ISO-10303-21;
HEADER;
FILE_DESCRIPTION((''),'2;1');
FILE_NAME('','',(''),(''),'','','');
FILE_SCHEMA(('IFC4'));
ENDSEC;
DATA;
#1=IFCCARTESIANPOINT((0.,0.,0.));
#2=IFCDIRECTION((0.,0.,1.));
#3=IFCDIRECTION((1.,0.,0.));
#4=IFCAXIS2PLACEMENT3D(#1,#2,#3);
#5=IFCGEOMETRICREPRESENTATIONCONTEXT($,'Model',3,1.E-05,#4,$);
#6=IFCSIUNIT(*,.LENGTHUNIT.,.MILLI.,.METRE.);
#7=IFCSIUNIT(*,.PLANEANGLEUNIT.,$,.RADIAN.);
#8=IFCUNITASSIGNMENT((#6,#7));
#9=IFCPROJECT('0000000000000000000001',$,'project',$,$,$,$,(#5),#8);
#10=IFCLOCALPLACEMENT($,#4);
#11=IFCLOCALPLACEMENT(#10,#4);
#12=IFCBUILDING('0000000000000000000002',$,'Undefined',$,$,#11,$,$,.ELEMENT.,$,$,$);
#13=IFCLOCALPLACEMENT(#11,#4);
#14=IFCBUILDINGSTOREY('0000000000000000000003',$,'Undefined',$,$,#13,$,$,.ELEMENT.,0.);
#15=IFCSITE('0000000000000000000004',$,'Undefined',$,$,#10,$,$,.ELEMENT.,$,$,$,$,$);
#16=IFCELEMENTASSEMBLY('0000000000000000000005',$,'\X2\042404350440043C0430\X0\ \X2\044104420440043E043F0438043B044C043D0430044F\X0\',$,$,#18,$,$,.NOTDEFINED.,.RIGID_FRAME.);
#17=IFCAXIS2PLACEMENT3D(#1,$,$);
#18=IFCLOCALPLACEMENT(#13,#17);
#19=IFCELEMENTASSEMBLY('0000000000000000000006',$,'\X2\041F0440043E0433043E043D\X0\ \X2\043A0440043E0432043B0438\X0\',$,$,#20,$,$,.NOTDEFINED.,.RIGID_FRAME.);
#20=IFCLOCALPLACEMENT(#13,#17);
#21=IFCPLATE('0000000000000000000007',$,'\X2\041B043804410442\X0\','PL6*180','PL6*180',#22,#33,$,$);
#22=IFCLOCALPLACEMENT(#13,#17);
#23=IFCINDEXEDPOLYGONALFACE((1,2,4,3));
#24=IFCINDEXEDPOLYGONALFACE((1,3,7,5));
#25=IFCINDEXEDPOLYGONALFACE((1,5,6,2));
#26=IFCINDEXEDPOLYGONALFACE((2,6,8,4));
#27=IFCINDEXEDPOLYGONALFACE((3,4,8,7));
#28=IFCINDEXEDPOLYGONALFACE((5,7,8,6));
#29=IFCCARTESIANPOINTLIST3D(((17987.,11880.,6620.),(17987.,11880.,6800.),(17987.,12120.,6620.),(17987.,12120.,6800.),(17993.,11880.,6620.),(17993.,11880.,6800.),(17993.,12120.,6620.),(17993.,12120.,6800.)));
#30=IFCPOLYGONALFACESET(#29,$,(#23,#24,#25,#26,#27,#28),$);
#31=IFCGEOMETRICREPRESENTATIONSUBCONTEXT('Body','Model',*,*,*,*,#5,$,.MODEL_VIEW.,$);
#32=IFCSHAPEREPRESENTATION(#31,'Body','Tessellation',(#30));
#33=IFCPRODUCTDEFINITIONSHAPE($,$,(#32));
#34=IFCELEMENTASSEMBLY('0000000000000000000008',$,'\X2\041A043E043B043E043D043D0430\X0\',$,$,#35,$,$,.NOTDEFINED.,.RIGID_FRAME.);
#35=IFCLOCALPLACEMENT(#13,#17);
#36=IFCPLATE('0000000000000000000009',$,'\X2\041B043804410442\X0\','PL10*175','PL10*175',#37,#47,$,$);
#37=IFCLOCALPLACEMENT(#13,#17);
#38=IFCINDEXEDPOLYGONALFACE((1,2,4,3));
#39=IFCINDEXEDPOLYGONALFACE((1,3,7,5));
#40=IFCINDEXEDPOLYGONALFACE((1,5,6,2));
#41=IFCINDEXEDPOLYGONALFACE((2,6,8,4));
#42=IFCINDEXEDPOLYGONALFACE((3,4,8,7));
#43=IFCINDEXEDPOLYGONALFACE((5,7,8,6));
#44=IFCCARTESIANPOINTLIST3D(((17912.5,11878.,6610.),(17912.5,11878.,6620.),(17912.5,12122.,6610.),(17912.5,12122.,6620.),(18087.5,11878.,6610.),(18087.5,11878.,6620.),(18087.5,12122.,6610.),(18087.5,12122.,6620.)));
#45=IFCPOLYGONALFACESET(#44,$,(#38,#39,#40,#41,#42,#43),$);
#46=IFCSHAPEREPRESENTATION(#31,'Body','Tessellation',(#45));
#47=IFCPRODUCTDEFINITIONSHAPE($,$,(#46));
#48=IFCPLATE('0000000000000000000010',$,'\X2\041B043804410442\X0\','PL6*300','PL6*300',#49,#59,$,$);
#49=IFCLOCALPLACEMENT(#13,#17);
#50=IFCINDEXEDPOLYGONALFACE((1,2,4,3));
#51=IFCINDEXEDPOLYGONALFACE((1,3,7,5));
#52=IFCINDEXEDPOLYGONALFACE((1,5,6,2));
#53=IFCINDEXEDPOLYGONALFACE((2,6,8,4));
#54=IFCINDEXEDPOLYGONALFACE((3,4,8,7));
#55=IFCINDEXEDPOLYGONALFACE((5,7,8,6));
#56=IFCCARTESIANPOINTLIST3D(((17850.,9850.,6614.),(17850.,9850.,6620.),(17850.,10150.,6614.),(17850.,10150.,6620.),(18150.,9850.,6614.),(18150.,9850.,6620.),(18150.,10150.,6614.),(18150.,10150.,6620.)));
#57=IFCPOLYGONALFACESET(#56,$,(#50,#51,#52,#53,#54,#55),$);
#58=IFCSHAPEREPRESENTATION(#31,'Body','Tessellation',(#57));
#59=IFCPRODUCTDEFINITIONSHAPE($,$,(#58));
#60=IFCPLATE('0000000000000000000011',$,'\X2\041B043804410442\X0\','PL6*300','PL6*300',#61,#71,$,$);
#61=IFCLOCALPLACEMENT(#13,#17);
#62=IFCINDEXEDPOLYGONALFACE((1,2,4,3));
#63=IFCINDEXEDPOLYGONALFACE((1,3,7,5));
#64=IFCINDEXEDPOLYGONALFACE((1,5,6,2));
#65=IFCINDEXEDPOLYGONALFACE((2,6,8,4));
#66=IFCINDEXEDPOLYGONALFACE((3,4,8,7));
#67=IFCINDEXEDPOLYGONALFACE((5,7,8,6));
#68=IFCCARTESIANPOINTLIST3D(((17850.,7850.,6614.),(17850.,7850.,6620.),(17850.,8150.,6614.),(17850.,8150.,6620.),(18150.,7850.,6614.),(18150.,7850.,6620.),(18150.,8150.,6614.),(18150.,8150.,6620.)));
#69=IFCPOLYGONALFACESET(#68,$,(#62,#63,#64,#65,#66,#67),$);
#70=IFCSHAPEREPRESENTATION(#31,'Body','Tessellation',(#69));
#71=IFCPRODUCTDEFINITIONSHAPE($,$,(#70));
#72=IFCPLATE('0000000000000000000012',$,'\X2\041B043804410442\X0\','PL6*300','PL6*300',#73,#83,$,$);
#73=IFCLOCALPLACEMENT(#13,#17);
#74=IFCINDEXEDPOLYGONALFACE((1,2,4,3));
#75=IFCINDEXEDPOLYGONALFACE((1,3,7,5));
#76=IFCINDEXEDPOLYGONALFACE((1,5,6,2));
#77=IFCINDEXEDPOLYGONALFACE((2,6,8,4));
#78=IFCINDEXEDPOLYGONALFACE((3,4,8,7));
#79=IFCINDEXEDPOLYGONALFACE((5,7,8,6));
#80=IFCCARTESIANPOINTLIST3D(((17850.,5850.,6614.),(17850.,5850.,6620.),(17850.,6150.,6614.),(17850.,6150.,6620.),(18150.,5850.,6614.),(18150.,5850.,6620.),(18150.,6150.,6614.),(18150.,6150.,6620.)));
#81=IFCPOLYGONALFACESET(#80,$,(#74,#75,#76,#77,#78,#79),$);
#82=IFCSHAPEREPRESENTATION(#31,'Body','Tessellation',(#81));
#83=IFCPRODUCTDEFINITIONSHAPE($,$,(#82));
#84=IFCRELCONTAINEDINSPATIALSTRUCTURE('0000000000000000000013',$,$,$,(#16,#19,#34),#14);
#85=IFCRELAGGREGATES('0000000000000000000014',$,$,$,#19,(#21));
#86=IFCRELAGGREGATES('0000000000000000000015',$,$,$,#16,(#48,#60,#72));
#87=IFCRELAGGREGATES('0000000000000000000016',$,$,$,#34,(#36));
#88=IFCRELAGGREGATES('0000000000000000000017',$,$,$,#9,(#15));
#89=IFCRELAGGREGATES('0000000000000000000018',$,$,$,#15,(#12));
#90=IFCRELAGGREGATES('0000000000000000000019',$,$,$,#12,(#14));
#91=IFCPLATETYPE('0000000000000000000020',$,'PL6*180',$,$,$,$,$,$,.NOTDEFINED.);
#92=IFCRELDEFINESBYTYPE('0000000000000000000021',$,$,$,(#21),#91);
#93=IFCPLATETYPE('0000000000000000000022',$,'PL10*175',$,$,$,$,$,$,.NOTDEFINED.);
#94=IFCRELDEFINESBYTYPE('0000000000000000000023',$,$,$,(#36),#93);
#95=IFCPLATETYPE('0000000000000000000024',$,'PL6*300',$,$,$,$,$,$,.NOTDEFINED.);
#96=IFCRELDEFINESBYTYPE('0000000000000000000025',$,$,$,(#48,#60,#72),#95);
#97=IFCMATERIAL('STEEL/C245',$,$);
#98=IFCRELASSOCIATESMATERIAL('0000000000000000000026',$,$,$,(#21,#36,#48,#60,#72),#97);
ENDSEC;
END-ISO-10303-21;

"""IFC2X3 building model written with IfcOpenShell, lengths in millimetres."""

from ifc_helpers import new_model, si_unit, frame, origin_with_axes, place, context, subcontext, project, spatial, polyline, outline, extrude, material, type_object, element, aggregate, save


model = new_model("IFC2X3")

# Units and contexts
model_context = context("Model", 3, precision=1e-05, world=origin_with_axes())
body_context = subcontext(model_context, "Body", "Model", "MODEL_VIEW")
ifc_project = project(units=[si_unit("LENGTHUNIT", "METRE", prefix="MILLI"), si_unit("PLANEANGLEUNIT", "RADIAN")], contexts=[model_context])

# Site, building, storey
site_placement = place(None, origin_with_axes())
site = spatial("IfcSite", under=ifc_project, at=site_placement, Name="Undefined", CompositionType="ELEMENT")
building_placement = place(site_placement, origin_with_axes())
building = spatial("IfcBuilding", under=site, at=building_placement, Name="Undefined", CompositionType="ELEMENT")
storey_placement = place(building_placement, origin_with_axes())
storey = spatial("IfcBuildingStorey", under=building, at=storey_placement, Name="Undefined", CompositionType="ELEMENT", Elevation=0.0)

# Shared definitions
ifc_material_1 = material(Name="STEEL/C245")

# Element assembly
assembly_1_placement = place(storey_placement, origin_with_axes())
assembly_1 = element("IfcElementAssembly", 1, at=assembly_1_placement, inside=storey, Name="Ферма стропильная", AssemblyPlace="NOTDEFINED", PredefinedType="RIGID_FRAME")

# Element assemblies, plates
assembly_2_placement = place(storey_placement, origin_with_axes())
assembly_2 = element("IfcElementAssembly", 2, at=assembly_2_placement, inside=storey, Name="Прогон кровли", AssemblyPlace="NOTDEFINED", PredefinedType="RIGID_FRAME")
plate_type_1 = type_object("IfcPlateType", Name="PL6*180", PredefinedType="NOTDEFINED")
plate_1_placement = place(assembly_2_placement, frame((17990.0, 11880.0, 6620.0), z_axis=(-1.0, 0.0, 0.0), x_axis=(0.0, 0.0, 1.0)))
plate_1 = element("IfcPlate", 3, at=plate_1_placement, type_object=plate_type_1, material=ifc_material_1, Name="Лист", Description="PL6*180", ObjectType="PL6*180", context=body_context, shape_type="SweptSolid", body=[
    extrude(outline(polyline([(0.0, 0.0), (180.0, 0.0), (180.0, 240.0), (0.0, 240.0), (0.0, 0.0)])), frame((0.0, 0.0, -3.0), z_axis=(0.0, 0.0, 1.0), x_axis=(1.0, 0.0, 0.0)), (0.0, 0.0, 1.0), 6.0),
])
aggregate(assembly_2, [plate_1])
assembly_3_placement = place(storey_placement, origin_with_axes())
assembly_3 = element("IfcElementAssembly", 4, at=assembly_3_placement, inside=storey, Name="Колонна", AssemblyPlace="NOTDEFINED", PredefinedType="RIGID_FRAME")
plate_type_2 = type_object("IfcPlateType", Name="PL10*175", PredefinedType="NOTDEFINED")
plate_2_placement = place(assembly_3_placement, frame((17912.5, 11878.0, 6615.0), z_axis=(0.0, 0.0, -1.0), x_axis=(0.0, 1.0, 0.0)))
plate_2 = element("IfcPlate", 5, at=plate_2_placement, type_object=plate_type_2, material=ifc_material_1, Name="Лист", Description="PL10*175", ObjectType="PL10*175", context=body_context, shape_type="SweptSolid", body=[
    extrude(outline(polyline([(0.0, 0.0), (244.0, 0.0), (244.0, 175.0), (0.0, 175.0), (0.0, 0.0)])), frame((0.0, 0.0, -5.0), z_axis=(0.0, 0.0, 1.0), x_axis=(1.0, 0.0, 0.0)), (0.0, 0.0, 1.0), 10.0),
])

# Plates
plate_type_3 = type_object("IfcPlateType", Name="PL6*300", PredefinedType="NOTDEFINED")
plate_3_placement = place(assembly_1_placement, frame((17850.0, 10150.0, 6617.0), z_axis=(0.0, 0.0, -1.0), x_axis=(1.0, 0.0, 0.0)))
plate_3 = element("IfcPlate", 6, at=plate_3_placement, type_object=plate_type_3, material=ifc_material_1, Name="Лист", Description="PL6*300", ObjectType="PL6*300", context=body_context, shape_type="SweptSolid", body=[
    extrude(outline(polyline([(0.0, 0.0), (300.0, 0.0), (300.0, 300.0), (0.0, 300.0), (0.0, 0.0)])), frame((0.0, 0.0, -3.0), z_axis=(0.0, 0.0, 1.0), x_axis=(1.0, 0.0, 0.0)), (0.0, 0.0, 1.0), 6.0),
])
plate_4_placement = place(assembly_1_placement, frame((17850.0, 8150.0, 6617.0), z_axis=(0.0, 0.0, -1.0), x_axis=(1.0, 0.0, 0.0)))
plate_4 = element("IfcPlate", 7, at=plate_4_placement, type_object=plate_type_3, material=ifc_material_1, Name="Лист", Description="PL6*300", ObjectType="PL6*300", context=body_context, shape_type="SweptSolid", body=[
    extrude(outline(polyline([(0.0, 0.0), (300.0, 0.0), (300.0, 300.0), (0.0, 300.0), (0.0, 0.0)])), frame((0.0, 0.0, -3.0), z_axis=(0.0, 0.0, 1.0), x_axis=(1.0, 0.0, 0.0)), (0.0, 0.0, 1.0), 6.0),
])
plate_5_placement = place(assembly_1_placement, frame((17850.0, 6150.0, 6617.0), z_axis=(0.0, 0.0, -1.0), x_axis=(1.0, 0.0, 0.0)))
plate_5 = element("IfcPlate", 8, at=plate_5_placement, type_object=plate_type_3, material=ifc_material_1, Name="Лист", Description="PL6*300", ObjectType="PL6*300", context=body_context, shape_type="SweptSolid", body=[
    extrude(outline(polyline([(0.0, 0.0), (300.0, 0.0), (300.0, 300.0), (0.0, 300.0), (0.0, 0.0)])), frame((0.0, 0.0, -3.0), z_axis=(0.0, 0.0, 1.0), x_axis=(1.0, 0.0, 0.0)), (0.0, 0.0, 1.0), 6.0),
])
aggregate(assembly_1, [plate_3, plate_4, plate_5])

aggregate(assembly_3, [plate_2])

save(model, "model.ifc")
